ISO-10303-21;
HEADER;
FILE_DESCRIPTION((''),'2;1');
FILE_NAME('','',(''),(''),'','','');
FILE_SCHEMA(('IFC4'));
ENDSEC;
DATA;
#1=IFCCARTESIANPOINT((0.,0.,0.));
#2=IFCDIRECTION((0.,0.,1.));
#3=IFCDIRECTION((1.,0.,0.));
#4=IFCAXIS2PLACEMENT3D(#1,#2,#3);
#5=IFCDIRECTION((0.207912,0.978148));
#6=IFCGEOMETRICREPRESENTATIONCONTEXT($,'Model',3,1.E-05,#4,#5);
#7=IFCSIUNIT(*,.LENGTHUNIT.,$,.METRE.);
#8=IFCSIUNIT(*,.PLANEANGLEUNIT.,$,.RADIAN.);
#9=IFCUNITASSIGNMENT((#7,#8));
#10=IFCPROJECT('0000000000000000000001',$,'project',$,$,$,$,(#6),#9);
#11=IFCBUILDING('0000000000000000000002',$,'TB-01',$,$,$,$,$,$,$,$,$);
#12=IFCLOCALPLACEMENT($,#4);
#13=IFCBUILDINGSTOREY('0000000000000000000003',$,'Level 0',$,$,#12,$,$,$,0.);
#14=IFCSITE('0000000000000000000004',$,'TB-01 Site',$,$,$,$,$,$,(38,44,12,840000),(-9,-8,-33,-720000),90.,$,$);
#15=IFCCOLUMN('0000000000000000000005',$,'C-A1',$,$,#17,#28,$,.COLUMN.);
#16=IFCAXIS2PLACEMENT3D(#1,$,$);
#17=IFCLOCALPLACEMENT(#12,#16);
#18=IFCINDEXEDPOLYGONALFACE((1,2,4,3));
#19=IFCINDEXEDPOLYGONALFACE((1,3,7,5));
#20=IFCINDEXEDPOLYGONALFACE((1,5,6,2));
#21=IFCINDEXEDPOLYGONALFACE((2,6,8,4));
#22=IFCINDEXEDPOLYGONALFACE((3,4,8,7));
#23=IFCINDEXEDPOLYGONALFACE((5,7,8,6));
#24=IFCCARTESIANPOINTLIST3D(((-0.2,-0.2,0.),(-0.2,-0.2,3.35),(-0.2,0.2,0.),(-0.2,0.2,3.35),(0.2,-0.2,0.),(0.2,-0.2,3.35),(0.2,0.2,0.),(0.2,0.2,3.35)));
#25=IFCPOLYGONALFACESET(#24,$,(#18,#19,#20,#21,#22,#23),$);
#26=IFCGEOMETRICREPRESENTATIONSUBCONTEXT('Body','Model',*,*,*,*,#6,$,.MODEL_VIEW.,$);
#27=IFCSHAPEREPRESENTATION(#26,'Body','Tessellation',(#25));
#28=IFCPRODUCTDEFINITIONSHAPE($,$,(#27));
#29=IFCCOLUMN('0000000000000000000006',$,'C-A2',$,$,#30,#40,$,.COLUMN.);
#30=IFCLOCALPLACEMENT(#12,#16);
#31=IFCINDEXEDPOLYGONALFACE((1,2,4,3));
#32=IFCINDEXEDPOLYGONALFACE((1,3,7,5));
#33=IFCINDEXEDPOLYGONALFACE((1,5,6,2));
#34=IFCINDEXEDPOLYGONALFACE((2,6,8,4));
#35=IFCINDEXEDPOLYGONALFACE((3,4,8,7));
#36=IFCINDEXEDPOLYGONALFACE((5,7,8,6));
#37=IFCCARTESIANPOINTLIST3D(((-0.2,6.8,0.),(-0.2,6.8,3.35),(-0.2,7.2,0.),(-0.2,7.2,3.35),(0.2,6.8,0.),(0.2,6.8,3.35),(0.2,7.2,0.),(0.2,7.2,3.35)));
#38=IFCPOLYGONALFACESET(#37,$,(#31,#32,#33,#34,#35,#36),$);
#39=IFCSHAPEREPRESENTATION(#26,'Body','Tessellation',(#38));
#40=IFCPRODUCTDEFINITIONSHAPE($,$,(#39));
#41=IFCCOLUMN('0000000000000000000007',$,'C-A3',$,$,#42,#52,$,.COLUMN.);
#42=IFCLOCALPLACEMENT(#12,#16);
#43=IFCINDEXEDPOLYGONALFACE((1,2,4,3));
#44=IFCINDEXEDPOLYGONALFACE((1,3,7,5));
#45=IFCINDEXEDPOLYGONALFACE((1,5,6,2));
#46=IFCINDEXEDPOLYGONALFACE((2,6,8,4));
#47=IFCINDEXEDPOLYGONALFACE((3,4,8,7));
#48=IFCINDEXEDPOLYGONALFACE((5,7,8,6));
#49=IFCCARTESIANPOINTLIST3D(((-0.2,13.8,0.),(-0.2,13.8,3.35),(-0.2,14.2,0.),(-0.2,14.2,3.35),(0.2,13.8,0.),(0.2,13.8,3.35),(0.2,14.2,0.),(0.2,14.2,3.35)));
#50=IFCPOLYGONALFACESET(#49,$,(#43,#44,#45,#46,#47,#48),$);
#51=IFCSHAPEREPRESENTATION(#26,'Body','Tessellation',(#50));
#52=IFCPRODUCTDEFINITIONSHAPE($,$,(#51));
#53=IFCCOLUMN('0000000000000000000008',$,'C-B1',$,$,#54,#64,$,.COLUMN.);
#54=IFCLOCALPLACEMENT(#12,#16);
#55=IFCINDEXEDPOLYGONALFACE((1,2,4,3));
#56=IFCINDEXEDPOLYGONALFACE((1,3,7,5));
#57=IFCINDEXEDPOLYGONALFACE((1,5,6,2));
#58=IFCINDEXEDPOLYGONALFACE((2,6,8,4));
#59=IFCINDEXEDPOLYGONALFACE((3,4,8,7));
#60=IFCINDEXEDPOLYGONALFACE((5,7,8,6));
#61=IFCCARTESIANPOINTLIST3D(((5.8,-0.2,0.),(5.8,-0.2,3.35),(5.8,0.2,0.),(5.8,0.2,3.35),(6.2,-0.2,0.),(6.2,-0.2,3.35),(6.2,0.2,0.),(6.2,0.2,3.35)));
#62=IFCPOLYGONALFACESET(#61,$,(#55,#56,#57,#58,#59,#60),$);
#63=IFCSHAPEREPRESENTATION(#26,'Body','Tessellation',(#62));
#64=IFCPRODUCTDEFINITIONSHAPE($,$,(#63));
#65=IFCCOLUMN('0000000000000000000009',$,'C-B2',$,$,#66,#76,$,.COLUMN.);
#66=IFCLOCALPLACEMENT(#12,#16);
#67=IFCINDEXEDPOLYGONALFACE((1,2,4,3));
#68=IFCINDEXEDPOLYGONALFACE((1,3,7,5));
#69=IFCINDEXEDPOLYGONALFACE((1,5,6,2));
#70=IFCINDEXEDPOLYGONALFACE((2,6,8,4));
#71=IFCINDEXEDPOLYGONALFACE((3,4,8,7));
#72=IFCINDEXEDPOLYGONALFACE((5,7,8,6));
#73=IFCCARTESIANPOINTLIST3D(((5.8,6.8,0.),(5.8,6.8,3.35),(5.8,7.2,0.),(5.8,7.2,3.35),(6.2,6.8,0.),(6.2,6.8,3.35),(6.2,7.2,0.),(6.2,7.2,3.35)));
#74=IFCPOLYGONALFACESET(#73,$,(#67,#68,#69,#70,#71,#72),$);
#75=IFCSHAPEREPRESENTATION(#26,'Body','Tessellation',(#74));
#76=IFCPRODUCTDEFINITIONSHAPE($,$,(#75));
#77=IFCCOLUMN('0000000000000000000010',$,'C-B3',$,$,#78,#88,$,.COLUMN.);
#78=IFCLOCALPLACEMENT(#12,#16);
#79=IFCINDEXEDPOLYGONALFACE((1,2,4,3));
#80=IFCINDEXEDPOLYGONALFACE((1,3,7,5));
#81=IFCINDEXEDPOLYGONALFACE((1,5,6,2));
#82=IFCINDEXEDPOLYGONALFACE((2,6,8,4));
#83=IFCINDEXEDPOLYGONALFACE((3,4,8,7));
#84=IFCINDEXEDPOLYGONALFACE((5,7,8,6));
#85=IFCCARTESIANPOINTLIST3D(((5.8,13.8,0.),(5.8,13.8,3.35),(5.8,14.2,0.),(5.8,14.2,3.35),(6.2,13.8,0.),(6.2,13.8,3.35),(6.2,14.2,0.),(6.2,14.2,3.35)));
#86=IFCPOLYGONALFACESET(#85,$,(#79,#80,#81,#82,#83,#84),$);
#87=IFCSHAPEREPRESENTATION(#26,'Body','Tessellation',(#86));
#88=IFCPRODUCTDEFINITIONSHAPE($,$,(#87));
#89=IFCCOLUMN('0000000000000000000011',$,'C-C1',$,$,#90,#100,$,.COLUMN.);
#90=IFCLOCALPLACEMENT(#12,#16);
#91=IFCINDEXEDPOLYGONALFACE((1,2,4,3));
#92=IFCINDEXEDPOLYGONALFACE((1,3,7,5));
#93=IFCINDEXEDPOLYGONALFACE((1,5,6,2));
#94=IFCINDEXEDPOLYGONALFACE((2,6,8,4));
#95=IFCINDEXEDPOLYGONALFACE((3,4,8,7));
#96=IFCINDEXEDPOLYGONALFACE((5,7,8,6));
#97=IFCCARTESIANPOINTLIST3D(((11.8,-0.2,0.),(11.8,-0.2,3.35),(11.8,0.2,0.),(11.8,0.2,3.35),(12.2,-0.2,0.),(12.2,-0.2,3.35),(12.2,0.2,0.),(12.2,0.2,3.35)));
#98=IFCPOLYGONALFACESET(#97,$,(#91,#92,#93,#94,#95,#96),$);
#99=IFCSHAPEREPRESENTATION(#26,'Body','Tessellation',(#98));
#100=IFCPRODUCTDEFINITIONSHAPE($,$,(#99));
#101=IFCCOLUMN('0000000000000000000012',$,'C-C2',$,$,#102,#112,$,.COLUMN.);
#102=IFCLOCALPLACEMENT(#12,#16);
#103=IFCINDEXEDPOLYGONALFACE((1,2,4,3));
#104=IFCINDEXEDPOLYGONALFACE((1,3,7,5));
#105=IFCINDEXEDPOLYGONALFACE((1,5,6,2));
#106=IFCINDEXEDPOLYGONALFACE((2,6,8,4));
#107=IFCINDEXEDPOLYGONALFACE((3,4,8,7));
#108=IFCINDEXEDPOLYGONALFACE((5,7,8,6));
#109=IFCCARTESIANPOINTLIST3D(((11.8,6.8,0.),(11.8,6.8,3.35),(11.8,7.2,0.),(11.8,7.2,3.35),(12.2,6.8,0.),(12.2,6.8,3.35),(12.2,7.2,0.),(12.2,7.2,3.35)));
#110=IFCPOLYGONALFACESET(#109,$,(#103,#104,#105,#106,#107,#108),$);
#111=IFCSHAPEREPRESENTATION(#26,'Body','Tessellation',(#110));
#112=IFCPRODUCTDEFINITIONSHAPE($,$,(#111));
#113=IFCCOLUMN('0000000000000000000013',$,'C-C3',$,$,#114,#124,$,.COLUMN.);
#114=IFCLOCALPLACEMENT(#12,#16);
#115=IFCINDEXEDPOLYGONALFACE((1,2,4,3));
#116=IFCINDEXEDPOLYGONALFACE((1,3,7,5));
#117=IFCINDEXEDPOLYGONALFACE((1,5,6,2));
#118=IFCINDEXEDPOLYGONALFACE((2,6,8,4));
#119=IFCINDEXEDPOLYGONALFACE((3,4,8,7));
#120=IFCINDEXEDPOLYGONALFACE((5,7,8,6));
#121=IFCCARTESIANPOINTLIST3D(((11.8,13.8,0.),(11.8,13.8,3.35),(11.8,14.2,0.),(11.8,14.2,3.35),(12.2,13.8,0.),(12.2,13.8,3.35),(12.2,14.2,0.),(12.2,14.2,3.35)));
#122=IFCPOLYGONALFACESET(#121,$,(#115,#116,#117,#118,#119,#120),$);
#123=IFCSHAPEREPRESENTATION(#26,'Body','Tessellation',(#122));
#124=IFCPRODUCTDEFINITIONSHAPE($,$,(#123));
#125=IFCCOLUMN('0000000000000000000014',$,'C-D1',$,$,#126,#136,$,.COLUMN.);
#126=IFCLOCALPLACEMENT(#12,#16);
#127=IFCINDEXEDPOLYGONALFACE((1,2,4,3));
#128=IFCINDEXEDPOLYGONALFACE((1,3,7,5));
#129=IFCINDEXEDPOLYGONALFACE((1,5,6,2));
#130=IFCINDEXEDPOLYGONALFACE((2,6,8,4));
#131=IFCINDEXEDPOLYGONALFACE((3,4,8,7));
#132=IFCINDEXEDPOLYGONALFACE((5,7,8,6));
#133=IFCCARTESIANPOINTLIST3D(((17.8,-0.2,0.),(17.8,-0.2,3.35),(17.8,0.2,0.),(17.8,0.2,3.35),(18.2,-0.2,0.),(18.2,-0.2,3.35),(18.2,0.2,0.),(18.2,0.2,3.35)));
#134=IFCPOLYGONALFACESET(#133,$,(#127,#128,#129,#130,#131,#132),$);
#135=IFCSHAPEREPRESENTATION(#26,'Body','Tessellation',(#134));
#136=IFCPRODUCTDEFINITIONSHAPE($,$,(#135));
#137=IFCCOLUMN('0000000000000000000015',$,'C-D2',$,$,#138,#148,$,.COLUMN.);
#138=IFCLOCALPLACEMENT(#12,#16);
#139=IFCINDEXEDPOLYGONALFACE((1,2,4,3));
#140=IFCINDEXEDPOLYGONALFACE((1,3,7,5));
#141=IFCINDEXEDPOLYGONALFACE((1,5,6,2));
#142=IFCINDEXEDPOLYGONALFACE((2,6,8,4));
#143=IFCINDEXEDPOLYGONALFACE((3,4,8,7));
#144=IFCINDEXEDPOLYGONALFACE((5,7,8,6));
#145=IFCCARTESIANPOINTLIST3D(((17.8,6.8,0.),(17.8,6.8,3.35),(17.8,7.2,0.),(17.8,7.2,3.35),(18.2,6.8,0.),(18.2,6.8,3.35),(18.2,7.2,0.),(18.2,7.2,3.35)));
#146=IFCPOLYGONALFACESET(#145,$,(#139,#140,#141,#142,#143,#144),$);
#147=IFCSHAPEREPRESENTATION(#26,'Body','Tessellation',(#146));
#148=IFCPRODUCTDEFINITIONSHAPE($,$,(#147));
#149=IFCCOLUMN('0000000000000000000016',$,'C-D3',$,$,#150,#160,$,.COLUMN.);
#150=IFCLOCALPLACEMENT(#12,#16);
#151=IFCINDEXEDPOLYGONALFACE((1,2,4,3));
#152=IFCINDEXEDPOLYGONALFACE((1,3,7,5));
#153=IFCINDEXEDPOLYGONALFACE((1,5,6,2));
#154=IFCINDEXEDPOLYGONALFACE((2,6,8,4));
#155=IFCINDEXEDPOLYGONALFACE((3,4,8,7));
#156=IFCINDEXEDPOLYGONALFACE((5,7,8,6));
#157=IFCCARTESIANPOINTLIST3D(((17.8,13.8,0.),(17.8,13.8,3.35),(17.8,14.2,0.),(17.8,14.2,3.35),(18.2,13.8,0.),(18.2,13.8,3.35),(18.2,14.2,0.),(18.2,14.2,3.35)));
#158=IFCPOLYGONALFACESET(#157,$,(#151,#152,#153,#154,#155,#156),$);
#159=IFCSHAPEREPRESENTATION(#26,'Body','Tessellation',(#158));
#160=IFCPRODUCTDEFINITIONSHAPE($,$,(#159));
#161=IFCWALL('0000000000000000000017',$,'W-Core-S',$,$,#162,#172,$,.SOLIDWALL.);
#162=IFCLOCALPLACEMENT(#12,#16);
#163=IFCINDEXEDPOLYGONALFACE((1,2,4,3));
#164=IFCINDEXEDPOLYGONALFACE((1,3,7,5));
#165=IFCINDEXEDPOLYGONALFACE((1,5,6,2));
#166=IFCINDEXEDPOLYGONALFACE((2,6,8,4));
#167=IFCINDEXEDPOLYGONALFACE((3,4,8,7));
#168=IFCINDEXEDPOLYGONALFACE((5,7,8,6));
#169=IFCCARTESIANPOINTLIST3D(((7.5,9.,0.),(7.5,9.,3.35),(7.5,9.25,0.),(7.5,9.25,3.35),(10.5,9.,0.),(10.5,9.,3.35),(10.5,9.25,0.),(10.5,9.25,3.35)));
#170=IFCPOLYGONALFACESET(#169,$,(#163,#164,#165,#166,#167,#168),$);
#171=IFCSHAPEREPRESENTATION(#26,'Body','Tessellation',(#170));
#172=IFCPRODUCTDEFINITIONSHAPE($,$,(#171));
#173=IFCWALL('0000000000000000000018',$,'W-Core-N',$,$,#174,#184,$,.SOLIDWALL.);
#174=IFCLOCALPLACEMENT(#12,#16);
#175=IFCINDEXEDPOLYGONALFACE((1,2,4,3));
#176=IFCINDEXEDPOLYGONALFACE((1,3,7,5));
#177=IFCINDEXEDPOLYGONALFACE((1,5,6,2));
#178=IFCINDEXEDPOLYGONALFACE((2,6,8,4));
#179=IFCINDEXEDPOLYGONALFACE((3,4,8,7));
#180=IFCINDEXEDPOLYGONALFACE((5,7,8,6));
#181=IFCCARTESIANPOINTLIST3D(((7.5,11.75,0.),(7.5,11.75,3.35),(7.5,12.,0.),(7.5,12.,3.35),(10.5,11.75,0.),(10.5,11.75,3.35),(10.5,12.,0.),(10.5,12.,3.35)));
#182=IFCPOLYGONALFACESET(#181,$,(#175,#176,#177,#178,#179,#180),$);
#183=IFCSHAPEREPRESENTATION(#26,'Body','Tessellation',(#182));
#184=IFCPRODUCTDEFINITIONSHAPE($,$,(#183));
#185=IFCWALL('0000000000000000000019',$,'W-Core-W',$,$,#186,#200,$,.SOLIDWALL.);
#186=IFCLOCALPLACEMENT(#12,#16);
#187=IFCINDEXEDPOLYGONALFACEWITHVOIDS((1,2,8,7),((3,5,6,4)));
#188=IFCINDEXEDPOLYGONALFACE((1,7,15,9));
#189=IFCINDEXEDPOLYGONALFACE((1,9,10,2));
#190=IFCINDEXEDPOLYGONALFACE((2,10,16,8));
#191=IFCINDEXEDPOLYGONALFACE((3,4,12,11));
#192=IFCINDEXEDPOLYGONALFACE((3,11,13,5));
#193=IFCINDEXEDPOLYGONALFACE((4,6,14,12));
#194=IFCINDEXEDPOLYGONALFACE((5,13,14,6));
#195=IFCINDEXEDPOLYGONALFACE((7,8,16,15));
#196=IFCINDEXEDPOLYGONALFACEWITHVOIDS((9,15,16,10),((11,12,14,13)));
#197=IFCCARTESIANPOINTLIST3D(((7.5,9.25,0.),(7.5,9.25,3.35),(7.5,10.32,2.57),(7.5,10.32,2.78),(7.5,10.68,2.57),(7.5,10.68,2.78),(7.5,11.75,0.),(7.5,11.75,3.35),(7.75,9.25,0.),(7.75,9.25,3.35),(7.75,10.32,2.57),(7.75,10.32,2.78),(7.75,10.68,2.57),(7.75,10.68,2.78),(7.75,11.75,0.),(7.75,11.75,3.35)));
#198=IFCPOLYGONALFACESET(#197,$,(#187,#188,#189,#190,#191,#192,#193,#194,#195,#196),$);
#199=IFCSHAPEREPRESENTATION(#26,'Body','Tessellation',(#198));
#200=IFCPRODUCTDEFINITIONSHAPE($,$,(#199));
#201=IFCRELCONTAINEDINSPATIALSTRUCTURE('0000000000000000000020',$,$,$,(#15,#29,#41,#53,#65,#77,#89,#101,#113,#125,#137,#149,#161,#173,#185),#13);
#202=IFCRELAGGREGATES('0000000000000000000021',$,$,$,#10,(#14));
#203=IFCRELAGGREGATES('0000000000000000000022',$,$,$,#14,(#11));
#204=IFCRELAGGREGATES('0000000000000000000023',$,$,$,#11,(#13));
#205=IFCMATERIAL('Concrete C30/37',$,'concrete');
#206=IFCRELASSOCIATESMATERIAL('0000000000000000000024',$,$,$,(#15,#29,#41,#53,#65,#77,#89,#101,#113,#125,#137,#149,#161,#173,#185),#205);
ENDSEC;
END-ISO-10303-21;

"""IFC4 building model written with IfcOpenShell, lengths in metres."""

from ifc_helpers import new_model, si_unit, direction, frame, origin_with_axes, place, context, subcontext, project, spatial, rectangle, extrude, material, element, save


model = new_model("IFC4")

# Units and contexts
model_context = context("Model", 3, precision=1e-05, world=origin_with_axes(), true_north=direction((0.207912, 0.978148)))
body_context = subcontext(model_context, "Body", "Model", "MODEL_VIEW")
ifc_project = project(units=[si_unit("LENGTHUNIT", "METRE"), si_unit("PLANEANGLEUNIT", "RADIAN")], contexts=[model_context])

# Site, building, storey
site = spatial("IfcSite", under=ifc_project, Name="TB-01 Site", RefLatitude=(38, 44, 12, 840000), RefLongitude=(-9, -8, -33, -720000), RefElevation=90.0)
building = spatial("IfcBuilding", under=site, Name="TB-01")
storey_placement = place(None, origin_with_axes())
storey = spatial("IfcBuildingStorey", under=building, at=storey_placement, Name="Level 0", Elevation=0.0)

# Columns
ifc_material = material(Name="Concrete C30/37", Category="concrete")
column_1_placement = place(storey_placement, origin_with_axes())
element("IfcColumn", 1, at=column_1_placement, inside=storey, material=ifc_material, Name="C-A1", PredefinedType="COLUMN", context=body_context, shape_type="SweptSolid", body=[
    extrude(rectangle(XDim=0.4, YDim=0.4), origin_with_axes(), (0.0, 0.0, 1.0), 3.35),
])
column_2_placement = place(storey_placement, frame((0.0, 7.0, 0.0), z_axis=(0.0, 0.0, 1.0), x_axis=(1.0, 0.0, 0.0)))
element("IfcColumn", 2, at=column_2_placement, inside=storey, material=ifc_material, Name="C-A2", PredefinedType="COLUMN", context=body_context, shape_type="SweptSolid", body=[
    extrude(rectangle(XDim=0.4, YDim=0.4), origin_with_axes(), (0.0, 0.0, 1.0), 3.35),
])
column_3_placement = place(storey_placement, frame((0.0, 14.0, 0.0), z_axis=(0.0, 0.0, 1.0), x_axis=(1.0, 0.0, 0.0)))
element("IfcColumn", 3, at=column_3_placement, inside=storey, material=ifc_material, Name="C-A3", PredefinedType="COLUMN", context=body_context, shape_type="SweptSolid", body=[
    extrude(rectangle(XDim=0.4, YDim=0.4), origin_with_axes(), (0.0, 0.0, 1.0), 3.35),
])
column_4_placement = place(storey_placement, frame((6.0, 0.0, 0.0), z_axis=(0.0, 0.0, 1.0), x_axis=(1.0, 0.0, 0.0)))
element("IfcColumn", 4, at=column_4_placement, inside=storey, material=ifc_material, Name="C-B1", PredefinedType="COLUMN", context=body_context, shape_type="SweptSolid", body=[
    extrude(rectangle(XDim=0.4, YDim=0.4), origin_with_axes(), (0.0, 0.0, 1.0), 3.35),
])
column_5_placement = place(storey_placement, frame((6.0, 7.0, 0.0), z_axis=(0.0, 0.0, 1.0), x_axis=(1.0, 0.0, 0.0)))
element("IfcColumn", 5, at=column_5_placement, inside=storey, material=ifc_material, Name="C-B2", PredefinedType="COLUMN", context=body_context, shape_type="SweptSolid", body=[
    extrude(rectangle(XDim=0.4, YDim=0.4), origin_with_axes(), (0.0, 0.0, 1.0), 3.35),
])
column_6_placement = place(storey_placement, frame((6.0, 14.0, 0.0), z_axis=(0.0, 0.0, 1.0), x_axis=(1.0, 0.0, 0.0)))
element("IfcColumn", 6, at=column_6_placement, inside=storey, material=ifc_material, Name="C-B3", PredefinedType="COLUMN", context=body_context, shape_type="SweptSolid", body=[
    extrude(rectangle(XDim=0.4, YDim=0.4), origin_with_axes(), (0.0, 0.0, 1.0), 3.35),
])
column_7_placement = place(storey_placement, frame((12.0, 0.0, 0.0), z_axis=(0.0, 0.0, 1.0), x_axis=(1.0, 0.0, 0.0)))
element("IfcColumn", 7, at=column_7_placement, inside=storey, material=ifc_material, Name="C-C1", PredefinedType="COLUMN", context=body_context, shape_type="SweptSolid", body=[
    extrude(rectangle(XDim=0.4, YDim=0.4), origin_with_axes(), (0.0, 0.0, 1.0), 3.35),
])
column_8_placement = place(storey_placement, frame((12.0, 7.0, 0.0), z_axis=(0.0, 0.0, 1.0), x_axis=(1.0, 0.0, 0.0)))
element("IfcColumn", 8, at=column_8_placement, inside=storey, material=ifc_material, Name="C-C2", PredefinedType="COLUMN", context=body_context, shape_type="SweptSolid", body=[
    extrude(rectangle(XDim=0.4, YDim=0.4), origin_with_axes(), (0.0, 0.0, 1.0), 3.35),
])
column_9_placement = place(storey_placement, frame((12.0, 14.0, 0.0), z_axis=(0.0, 0.0, 1.0), x_axis=(1.0, 0.0, 0.0)))
element("IfcColumn", 9, at=column_9_placement, inside=storey, material=ifc_material, Name="C-C3", PredefinedType="COLUMN", context=body_context, shape_type="SweptSolid", body=[
    extrude(rectangle(XDim=0.4, YDim=0.4), origin_with_axes(), (0.0, 0.0, 1.0), 3.35),
])
column_10_placement = place(storey_placement, frame((18.0, 0.0, 0.0), z_axis=(0.0, 0.0, 1.0), x_axis=(1.0, 0.0, 0.0)))
element("IfcColumn", 10, at=column_10_placement, inside=storey, material=ifc_material, Name="C-D1", PredefinedType="COLUMN", context=body_context, shape_type="SweptSolid", body=[
    extrude(rectangle(XDim=0.4, YDim=0.4), origin_with_axes(), (0.0, 0.0, 1.0), 3.35),
])
column_11_placement = place(storey_placement, frame((18.0, 7.0, 0.0), z_axis=(0.0, 0.0, 1.0), x_axis=(1.0, 0.0, 0.0)))
element("IfcColumn", 11, at=column_11_placement, inside=storey, material=ifc_material, Name="C-D2", PredefinedType="COLUMN", context=body_context, shape_type="SweptSolid", body=[
    extrude(rectangle(XDim=0.4, YDim=0.4), origin_with_axes(), (0.0, 0.0, 1.0), 3.35),
])
column_12_placement = place(storey_placement, frame((18.0, 14.0, 0.0), z_axis=(0.0, 0.0, 1.0), x_axis=(1.0, 0.0, 0.0)))
element("IfcColumn", 12, at=column_12_placement, inside=storey, material=ifc_material, Name="C-D3", PredefinedType="COLUMN", context=body_context, shape_type="SweptSolid", body=[
    extrude(rectangle(XDim=0.4, YDim=0.4), origin_with_axes(), (0.0, 0.0, 1.0), 3.35),
])

# Walls
for number, where, z_axis, x_axis, name in (
    (13, (9.0, 9.125, 0.0), (0.0, 0.0, 1.0), (1.0, 0.0, 0.0), "W-Core-S"),
    (14, (9.0, 11.875, 0.0), (0.0, 0.0, 1.0), (1.0, 0.0, 0.0), "W-Core-N"),
):
    element("IfcWall", number, at=place(storey_placement, frame(where, z_axis=z_axis, x_axis=x_axis)), inside=storey, material=ifc_material, Name=name, PredefinedType="SOLIDWALL", context=body_context, shape_type="SweptSolid", body=[
        extrude(rectangle(XDim=3.0, YDim=0.25), origin_with_axes(), (0.0, 0.0, 1.0), 3.35),
    ])

# Wall, opening
wall_1_placement = place(storey_placement, frame((7.625, 10.5, 0.0), z_axis=(0.0, 0.0, 1.0), x_axis=(1.0, 0.0, 0.0)))
wall_1 = element("IfcWall", 15, at=wall_1_placement, inside=storey, material=ifc_material, Name="W-Core-W", PredefinedType="SOLIDWALL", context=body_context, shape_type="SweptSolid", body=[
    extrude(rectangle(XDim=0.25, YDim=2.5), origin_with_axes(), (0.0, 0.0, 1.0), 3.35),
])
opening_1_placement = place(wall_1_placement, frame((0.0, 0.0, 2.57), z_axis=(0.0, 0.0, 1.0), x_axis=(1.0, 0.0, 0.0)))
element("IfcOpeningElement", 16, at=opening_1_placement, cuts=wall_1, context=body_context, shape_type="SweptSolid", body=[
    extrude(rectangle(XDim=0.35, YDim=0.36), origin_with_axes(), (0.0, 0.0, 1.0), 0.21),
])

save(model, "model.ifc")
